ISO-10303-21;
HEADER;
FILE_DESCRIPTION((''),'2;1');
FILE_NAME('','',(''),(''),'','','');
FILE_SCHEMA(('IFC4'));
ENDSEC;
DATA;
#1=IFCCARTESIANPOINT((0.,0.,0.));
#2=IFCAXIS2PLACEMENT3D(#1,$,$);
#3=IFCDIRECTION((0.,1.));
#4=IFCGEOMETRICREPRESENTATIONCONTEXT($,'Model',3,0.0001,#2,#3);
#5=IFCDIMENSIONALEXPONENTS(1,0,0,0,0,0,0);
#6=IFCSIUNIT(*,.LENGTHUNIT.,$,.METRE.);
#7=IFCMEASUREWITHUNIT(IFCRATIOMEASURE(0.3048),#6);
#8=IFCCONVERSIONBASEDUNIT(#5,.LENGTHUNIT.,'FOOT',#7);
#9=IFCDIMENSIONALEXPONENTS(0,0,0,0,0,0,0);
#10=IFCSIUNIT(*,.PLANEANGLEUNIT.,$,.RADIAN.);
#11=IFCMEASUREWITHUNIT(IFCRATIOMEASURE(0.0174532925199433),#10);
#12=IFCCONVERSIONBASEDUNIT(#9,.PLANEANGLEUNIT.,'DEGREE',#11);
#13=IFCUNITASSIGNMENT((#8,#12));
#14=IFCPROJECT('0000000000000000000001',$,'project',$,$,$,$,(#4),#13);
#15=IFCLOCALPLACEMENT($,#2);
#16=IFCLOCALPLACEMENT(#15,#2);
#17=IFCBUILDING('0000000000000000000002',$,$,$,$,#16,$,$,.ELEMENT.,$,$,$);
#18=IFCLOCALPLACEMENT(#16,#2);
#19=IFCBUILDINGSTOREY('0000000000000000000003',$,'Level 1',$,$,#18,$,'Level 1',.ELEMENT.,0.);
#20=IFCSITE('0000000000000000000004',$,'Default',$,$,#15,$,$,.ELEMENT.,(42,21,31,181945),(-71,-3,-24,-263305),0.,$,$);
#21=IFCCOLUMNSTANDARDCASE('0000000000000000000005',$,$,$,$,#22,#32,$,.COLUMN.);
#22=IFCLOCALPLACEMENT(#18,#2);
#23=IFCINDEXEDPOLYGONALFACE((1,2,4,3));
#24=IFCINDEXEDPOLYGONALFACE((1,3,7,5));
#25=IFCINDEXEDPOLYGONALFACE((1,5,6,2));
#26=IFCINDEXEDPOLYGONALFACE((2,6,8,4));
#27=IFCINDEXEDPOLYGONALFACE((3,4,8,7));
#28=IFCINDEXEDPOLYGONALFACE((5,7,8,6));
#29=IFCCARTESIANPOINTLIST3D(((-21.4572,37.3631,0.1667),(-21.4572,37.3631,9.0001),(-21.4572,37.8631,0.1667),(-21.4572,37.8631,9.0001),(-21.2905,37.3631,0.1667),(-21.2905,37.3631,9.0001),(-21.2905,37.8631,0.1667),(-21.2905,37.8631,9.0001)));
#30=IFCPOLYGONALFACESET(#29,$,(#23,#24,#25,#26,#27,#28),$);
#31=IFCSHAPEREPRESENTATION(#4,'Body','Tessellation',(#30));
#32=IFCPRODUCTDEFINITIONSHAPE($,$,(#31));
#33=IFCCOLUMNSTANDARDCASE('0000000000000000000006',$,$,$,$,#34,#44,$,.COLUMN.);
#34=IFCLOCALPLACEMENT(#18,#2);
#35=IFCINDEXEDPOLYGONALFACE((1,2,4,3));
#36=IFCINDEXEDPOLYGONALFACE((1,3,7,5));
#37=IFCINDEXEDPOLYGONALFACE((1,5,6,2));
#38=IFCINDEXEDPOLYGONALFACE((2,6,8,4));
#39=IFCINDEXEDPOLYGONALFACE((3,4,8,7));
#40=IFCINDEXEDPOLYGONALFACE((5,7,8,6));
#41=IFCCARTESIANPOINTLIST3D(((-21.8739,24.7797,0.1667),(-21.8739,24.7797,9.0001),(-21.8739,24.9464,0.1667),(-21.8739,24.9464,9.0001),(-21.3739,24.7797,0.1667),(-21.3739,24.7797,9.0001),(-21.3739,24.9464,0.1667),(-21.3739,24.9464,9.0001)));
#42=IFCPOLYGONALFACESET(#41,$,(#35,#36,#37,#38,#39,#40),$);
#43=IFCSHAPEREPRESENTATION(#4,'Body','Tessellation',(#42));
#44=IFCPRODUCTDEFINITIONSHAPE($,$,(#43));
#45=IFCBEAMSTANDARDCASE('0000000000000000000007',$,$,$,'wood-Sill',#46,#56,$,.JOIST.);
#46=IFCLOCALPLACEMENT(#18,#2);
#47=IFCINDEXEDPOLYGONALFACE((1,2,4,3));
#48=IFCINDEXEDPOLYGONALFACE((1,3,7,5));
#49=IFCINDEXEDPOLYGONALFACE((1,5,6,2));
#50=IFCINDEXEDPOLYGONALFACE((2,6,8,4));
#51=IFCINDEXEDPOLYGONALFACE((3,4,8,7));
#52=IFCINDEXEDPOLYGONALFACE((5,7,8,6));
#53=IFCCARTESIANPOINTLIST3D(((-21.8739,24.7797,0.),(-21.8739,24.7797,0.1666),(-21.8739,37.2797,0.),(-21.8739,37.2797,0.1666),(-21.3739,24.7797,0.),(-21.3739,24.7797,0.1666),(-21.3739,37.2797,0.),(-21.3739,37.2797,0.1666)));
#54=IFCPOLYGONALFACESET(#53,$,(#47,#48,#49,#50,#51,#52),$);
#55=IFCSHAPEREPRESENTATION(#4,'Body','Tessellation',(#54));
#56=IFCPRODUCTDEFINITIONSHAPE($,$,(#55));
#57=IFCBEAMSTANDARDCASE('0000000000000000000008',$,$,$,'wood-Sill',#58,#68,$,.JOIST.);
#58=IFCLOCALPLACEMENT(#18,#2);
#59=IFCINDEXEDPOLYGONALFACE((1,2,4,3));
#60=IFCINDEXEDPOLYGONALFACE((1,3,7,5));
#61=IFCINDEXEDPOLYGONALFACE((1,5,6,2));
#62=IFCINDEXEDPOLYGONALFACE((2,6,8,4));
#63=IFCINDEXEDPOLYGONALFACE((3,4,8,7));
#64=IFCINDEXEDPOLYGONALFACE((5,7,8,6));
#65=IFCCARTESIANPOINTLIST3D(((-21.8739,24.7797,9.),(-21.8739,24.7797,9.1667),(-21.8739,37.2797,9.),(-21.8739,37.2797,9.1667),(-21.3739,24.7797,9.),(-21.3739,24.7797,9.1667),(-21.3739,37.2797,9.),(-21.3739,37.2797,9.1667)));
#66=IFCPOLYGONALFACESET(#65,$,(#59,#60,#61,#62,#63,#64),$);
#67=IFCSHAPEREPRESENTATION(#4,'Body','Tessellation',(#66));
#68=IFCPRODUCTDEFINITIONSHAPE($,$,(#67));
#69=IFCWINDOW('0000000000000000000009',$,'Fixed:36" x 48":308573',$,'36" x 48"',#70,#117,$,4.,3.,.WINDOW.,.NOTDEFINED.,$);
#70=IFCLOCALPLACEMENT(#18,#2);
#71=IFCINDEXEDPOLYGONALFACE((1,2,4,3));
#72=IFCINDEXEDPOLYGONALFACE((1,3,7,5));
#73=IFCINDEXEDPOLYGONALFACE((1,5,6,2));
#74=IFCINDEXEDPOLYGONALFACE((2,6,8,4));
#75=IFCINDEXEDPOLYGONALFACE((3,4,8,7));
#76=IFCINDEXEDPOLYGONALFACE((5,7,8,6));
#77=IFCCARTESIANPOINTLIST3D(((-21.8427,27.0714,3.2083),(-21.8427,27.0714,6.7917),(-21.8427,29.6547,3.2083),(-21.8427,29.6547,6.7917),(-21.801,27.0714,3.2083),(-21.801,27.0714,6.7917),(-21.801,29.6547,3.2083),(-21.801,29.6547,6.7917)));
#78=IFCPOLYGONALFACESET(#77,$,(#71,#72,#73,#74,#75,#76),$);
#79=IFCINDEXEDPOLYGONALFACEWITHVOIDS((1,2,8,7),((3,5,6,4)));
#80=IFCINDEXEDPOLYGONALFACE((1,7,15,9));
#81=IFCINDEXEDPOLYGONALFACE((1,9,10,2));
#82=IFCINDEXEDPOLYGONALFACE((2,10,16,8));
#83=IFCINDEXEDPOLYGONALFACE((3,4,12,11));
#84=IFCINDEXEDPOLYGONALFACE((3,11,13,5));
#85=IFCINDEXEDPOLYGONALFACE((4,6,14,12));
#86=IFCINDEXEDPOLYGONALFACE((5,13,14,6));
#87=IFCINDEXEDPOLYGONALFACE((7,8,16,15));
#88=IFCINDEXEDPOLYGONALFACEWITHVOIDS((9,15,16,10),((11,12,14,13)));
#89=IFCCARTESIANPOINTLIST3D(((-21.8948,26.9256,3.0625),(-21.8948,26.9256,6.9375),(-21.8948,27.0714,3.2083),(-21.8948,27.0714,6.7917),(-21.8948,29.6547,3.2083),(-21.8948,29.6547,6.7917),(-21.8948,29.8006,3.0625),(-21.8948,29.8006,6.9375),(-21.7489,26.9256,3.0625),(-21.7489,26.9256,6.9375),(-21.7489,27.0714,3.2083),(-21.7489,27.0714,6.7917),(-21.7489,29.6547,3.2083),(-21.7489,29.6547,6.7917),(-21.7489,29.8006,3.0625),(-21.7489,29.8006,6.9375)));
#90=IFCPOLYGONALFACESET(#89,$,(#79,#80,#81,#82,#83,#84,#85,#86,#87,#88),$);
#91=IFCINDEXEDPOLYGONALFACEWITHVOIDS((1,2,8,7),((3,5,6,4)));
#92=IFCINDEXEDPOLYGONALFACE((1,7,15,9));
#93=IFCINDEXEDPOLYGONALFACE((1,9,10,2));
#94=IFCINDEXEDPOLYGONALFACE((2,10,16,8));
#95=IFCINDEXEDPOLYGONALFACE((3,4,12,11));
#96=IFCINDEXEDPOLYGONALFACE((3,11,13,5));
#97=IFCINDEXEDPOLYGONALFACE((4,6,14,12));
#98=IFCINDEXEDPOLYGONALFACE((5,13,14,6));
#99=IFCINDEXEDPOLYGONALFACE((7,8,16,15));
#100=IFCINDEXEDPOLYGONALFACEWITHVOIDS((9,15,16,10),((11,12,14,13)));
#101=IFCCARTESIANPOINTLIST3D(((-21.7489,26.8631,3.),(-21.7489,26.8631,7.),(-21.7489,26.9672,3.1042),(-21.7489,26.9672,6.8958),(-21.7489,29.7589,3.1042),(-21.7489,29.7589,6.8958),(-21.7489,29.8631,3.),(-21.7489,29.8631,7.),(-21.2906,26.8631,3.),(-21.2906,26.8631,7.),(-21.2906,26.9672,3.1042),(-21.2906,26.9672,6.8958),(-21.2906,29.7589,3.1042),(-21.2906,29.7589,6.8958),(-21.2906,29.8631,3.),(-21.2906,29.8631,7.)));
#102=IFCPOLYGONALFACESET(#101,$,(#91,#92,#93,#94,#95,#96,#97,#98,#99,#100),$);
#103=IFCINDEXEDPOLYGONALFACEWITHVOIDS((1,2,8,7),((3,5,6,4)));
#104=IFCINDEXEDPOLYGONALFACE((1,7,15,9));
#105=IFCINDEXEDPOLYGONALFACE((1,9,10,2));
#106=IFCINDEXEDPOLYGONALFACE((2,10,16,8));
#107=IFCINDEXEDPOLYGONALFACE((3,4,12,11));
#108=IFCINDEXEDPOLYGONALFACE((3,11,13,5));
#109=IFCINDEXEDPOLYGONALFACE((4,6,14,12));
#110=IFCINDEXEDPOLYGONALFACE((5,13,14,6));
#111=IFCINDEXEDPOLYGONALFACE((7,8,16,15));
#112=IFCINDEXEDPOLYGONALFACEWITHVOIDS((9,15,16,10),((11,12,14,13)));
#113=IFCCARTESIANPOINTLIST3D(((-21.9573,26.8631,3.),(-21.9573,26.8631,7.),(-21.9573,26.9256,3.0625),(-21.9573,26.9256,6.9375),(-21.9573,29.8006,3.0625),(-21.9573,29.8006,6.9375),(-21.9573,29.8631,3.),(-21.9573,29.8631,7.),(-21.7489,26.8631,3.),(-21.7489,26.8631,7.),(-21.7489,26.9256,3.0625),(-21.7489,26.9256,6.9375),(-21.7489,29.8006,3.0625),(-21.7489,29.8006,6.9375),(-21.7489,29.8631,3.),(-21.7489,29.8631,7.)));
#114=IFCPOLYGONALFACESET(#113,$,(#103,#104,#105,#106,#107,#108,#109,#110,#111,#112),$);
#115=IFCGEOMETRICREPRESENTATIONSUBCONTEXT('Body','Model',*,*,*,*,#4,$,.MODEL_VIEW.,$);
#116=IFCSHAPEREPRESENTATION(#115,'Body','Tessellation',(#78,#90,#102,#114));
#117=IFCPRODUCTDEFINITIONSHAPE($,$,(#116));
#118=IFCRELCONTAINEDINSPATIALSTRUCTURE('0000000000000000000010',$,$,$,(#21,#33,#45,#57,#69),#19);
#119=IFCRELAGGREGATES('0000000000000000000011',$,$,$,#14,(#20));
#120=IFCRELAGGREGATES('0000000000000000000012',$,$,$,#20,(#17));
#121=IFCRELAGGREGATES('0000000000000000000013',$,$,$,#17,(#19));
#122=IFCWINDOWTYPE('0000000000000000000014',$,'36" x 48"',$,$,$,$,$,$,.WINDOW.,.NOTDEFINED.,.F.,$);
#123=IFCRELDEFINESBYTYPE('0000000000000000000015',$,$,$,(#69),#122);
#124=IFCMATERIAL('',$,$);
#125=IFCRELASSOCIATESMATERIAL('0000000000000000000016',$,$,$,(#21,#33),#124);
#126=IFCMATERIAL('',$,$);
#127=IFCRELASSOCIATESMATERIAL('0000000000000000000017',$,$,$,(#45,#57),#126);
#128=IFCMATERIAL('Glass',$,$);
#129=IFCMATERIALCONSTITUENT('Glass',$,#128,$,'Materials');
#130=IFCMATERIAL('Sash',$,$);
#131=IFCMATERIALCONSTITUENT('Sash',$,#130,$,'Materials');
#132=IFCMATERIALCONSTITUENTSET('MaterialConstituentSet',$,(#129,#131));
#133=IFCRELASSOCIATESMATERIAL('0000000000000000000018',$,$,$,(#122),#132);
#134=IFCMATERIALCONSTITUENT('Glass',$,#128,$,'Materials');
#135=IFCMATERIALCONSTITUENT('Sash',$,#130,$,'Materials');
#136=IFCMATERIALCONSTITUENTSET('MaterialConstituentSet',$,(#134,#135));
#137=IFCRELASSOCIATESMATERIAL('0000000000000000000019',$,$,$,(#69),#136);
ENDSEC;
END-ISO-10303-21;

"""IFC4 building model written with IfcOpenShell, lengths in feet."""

from ifc_helpers import new_model, entity, si_unit, converted_unit, direction, frame, frame_2d, origin, origin_with_axes, place, context, subcontext, project, spatial, polyline, rectangle, outline, extrude, source, transform, mapped, material, constituent, constituent_set, type_object, type_shapes, element, save


model = new_model("IFC4")

# Units and contexts
model_context = context("Model", 3, precision=0.0001, world=origin(), true_north=direction((0.0, 1.0)))
body_context = subcontext(model_context, "Body", "Model", "MODEL_VIEW")
ifc_project = project(units=[converted_unit("LENGTHUNIT", "FOOT", entity("IfcRatioMeasure", 0.3048), si_unit("LENGTHUNIT", "METRE"), dimensions=[1, 0, 0, 0, 0, 0, 0]), converted_unit("PLANEANGLEUNIT", "DEGREE", entity("IfcRatioMeasure", 0.0174532925199433), si_unit("PLANEANGLEUNIT", "RADIAN"), dimensions=[0, 0, 0, 0, 0, 0, 0])], contexts=[model_context])

# Site, building, storey
site_placement = place(None, origin())
site = spatial("IfcSite", under=ifc_project, at=site_placement, Name="Default", CompositionType="ELEMENT", RefLatitude=(42, 21, 31, 181945), RefLongitude=(-71, -3, -24, -263305), RefElevation=0.0)
building_placement = place(site_placement, origin())
building = spatial("IfcBuilding", under=site, at=building_placement, CompositionType="ELEMENT")
storey_placement = place(building_placement, origin())
storey = spatial("IfcBuildingStorey", under=building, at=storey_placement, Name="Level 1", LongName="Level 1", CompositionType="ELEMENT", Elevation=0.0)

# Columns
ifc_material_1 = material(Name="")
placement_1 = place(storey_placement, frame((-21.2906, 37.6131, 0.0), z_axis=(0.0, 0.0, 1.0), x_axis=(-1.0, 0.0, 0.0)))
for number, where, z_axis, x_axis in (
    (1, (0.0833, 0.0, 0.1667), (0.0, 0.0, 1.0), (1.0, 0.0, 0.0)),
):
    element("IfcColumnStandardCase", number, at=place(placement_1, frame(where, z_axis=z_axis, x_axis=x_axis)), inside=storey, material=ifc_material_1, PredefinedType="COLUMN", context=model_context, shape_type="SweptSolid", body=[
        extrude(rectangle(XDim=0.1667, YDim=0.5), origin(), (0.0, 0.0, 1.0), 8.8334),
    ])
placement_2 = place(storey_placement, frame((-21.6239, 24.7797, 0.0), z_axis=(0.0, 0.0, 1.0), x_axis=(0.0, 1.0, 0.0)))
for number, where, z_axis, x_axis in (
    (2, (0.0833, 0.0, 0.1667), (0.0, 0.0, 1.0), (1.0, 0.0, 0.0)),
):
    element("IfcColumnStandardCase", number, at=place(placement_2, frame(where, z_axis=z_axis, x_axis=x_axis)), inside=storey, material=ifc_material_1, PredefinedType="COLUMN", context=model_context, shape_type="SweptSolid", body=[
        extrude(rectangle(XDim=0.1667, YDim=0.5), origin(), (0.0, 0.0, 1.0), 8.8334),
    ])

# Beams
ifc_material_2 = material(Name="")
for number, where, z_axis, x_axis in (
    (3, (0.0, 0.0, 0.0833), (1.0, 0.0, 0.0), (0.0, 0.0, 1.0)),
    (4, (0.0, 0.0, 9.0834), (1.0, 0.0, 0.0), (0.0, 0.0, 1.0)),
):
    element("IfcBeamStandardCase", number, at=place(placement_2, frame(where, z_axis=z_axis, x_axis=x_axis)), inside=storey, material=ifc_material_2, ObjectType="wood-Sill", PredefinedType="JOIST", context=model_context, shape_type="SweptSolid", body=[
        extrude(rectangle(XDim=0.1667, YDim=0.5), origin_with_axes(), (0.0, 0.0, 1.0), 12.5),
    ])

# Window
ifc_material_3 = material(Name="Glass")
ifc_constituent_1 = constituent(ifc_material_3, Name="Glass", Category="Materials")
ifc_material_4 = material(Name="Sash")
ifc_constituent_2 = constituent(ifc_material_4, Name="Sash", Category="Materials")
ifc_constituent_set_1 = constituent_set(constituents=[ifc_constituent_1, ifc_constituent_2], Name="MaterialConstituentSet")
ifc_constituent_3 = constituent(ifc_material_3, Name="Glass", Category="Materials")
ifc_constituent_4 = constituent(ifc_material_4, Name="Sash", Category="Materials")
ifc_constituent_set_2 = constituent_set(constituents=[ifc_constituent_3, ifc_constituent_4], Name="MaterialConstituentSet")
window_type = type_object("IfcWindowType", Name="36\" x 48\"", ParameterTakesPrecedence=False, PartitioningType="NOTDEFINED", PredefinedType="WINDOW", material=ifc_constituent_set_2)
shared_shape = source(origin(), body_context, "Body", "SweptSolid", [
    extrude(rectangle(XDim=2.5833, YDim=0.0417, at=frame_2d((0.0, 0.0), x_axis=(1.0, 0.0))), frame((1.75, 0.5312, 0.2083)), (0.0, 0.0, 1.0), 3.5833),
    extrude(outline(polyline([(-1.4375, -1.9375), (1.4375, -1.9375), (1.4375, 1.9375), (-1.4375, 1.9375), (-1.4375, -1.9375)]), holes=[polyline([(-1.2917, -1.7917), (-1.2917, 1.7917), (1.2917, 1.7917), (1.2917, -1.7917), (-1.2917, -1.7917)])]), frame((1.75, 0.6042, 2.0), z_axis=(0.0, -1.0, 0.0), x_axis=(-1.0, 0.0, 0.0)), (0.0, 0.0, 1.0), 0.1458),
    extrude(outline(polyline([(-1.5, -2.0), (1.5, -2.0), (1.5, 2.0), (-1.5, 2.0), (-1.5, -2.0)]), holes=[polyline([(-1.3958, -1.8958), (-1.3958, 1.8958), (1.3958, 1.8958), (1.3958, -1.8958), (-1.3958, -1.8958)])]), frame((1.75, 0.4583, 2.0), z_axis=(0.0, -1.0, 0.0), x_axis=(-1.0, 0.0, 0.0)), (0.0, 0.0, 1.0), 0.4583),
    extrude(outline(polyline([(-2.0, -1.5), (2.0, -1.5), (2.0, 1.5), (-2.0, 1.5), (-2.0, -1.5)]), holes=[polyline([(-1.9375, -1.4375), (-1.9375, 1.4375), (1.9375, 1.4375), (1.9375, -1.4375), (-1.9375, -1.4375)])]), frame((1.75, 0.6667, 2.0), z_axis=(0.0, -1.0, 0.0), x_axis=(0.0, 0.0, -1.0)), (0.0, 0.0, 1.0), 0.2083),
])
type_shapes(window_type, [shared_shape])
placement_3 = place(placement_2, frame((2.0833, -0.3333, 3.0)))
window_placement = place(placement_3, frame((-0.25, 0.0, 0.0)))
element("IfcWindow", 5, at=window_placement, inside=storey, type_object=window_type, material=ifc_constituent_set_1, Name="Fixed:36\" x 48\":308573", ObjectType="36\" x 48\"", OverallHeight=4.0, OverallWidth=3.0, PartitioningType="NOTDEFINED", PredefinedType="WINDOW", context=body_context, shape_type="MappedRepresentation", body=[
    mapped(shared_shape, transform((0.0, 0.0, 0.0), scale=1.0)),
])

save(model, "model.ifc")
